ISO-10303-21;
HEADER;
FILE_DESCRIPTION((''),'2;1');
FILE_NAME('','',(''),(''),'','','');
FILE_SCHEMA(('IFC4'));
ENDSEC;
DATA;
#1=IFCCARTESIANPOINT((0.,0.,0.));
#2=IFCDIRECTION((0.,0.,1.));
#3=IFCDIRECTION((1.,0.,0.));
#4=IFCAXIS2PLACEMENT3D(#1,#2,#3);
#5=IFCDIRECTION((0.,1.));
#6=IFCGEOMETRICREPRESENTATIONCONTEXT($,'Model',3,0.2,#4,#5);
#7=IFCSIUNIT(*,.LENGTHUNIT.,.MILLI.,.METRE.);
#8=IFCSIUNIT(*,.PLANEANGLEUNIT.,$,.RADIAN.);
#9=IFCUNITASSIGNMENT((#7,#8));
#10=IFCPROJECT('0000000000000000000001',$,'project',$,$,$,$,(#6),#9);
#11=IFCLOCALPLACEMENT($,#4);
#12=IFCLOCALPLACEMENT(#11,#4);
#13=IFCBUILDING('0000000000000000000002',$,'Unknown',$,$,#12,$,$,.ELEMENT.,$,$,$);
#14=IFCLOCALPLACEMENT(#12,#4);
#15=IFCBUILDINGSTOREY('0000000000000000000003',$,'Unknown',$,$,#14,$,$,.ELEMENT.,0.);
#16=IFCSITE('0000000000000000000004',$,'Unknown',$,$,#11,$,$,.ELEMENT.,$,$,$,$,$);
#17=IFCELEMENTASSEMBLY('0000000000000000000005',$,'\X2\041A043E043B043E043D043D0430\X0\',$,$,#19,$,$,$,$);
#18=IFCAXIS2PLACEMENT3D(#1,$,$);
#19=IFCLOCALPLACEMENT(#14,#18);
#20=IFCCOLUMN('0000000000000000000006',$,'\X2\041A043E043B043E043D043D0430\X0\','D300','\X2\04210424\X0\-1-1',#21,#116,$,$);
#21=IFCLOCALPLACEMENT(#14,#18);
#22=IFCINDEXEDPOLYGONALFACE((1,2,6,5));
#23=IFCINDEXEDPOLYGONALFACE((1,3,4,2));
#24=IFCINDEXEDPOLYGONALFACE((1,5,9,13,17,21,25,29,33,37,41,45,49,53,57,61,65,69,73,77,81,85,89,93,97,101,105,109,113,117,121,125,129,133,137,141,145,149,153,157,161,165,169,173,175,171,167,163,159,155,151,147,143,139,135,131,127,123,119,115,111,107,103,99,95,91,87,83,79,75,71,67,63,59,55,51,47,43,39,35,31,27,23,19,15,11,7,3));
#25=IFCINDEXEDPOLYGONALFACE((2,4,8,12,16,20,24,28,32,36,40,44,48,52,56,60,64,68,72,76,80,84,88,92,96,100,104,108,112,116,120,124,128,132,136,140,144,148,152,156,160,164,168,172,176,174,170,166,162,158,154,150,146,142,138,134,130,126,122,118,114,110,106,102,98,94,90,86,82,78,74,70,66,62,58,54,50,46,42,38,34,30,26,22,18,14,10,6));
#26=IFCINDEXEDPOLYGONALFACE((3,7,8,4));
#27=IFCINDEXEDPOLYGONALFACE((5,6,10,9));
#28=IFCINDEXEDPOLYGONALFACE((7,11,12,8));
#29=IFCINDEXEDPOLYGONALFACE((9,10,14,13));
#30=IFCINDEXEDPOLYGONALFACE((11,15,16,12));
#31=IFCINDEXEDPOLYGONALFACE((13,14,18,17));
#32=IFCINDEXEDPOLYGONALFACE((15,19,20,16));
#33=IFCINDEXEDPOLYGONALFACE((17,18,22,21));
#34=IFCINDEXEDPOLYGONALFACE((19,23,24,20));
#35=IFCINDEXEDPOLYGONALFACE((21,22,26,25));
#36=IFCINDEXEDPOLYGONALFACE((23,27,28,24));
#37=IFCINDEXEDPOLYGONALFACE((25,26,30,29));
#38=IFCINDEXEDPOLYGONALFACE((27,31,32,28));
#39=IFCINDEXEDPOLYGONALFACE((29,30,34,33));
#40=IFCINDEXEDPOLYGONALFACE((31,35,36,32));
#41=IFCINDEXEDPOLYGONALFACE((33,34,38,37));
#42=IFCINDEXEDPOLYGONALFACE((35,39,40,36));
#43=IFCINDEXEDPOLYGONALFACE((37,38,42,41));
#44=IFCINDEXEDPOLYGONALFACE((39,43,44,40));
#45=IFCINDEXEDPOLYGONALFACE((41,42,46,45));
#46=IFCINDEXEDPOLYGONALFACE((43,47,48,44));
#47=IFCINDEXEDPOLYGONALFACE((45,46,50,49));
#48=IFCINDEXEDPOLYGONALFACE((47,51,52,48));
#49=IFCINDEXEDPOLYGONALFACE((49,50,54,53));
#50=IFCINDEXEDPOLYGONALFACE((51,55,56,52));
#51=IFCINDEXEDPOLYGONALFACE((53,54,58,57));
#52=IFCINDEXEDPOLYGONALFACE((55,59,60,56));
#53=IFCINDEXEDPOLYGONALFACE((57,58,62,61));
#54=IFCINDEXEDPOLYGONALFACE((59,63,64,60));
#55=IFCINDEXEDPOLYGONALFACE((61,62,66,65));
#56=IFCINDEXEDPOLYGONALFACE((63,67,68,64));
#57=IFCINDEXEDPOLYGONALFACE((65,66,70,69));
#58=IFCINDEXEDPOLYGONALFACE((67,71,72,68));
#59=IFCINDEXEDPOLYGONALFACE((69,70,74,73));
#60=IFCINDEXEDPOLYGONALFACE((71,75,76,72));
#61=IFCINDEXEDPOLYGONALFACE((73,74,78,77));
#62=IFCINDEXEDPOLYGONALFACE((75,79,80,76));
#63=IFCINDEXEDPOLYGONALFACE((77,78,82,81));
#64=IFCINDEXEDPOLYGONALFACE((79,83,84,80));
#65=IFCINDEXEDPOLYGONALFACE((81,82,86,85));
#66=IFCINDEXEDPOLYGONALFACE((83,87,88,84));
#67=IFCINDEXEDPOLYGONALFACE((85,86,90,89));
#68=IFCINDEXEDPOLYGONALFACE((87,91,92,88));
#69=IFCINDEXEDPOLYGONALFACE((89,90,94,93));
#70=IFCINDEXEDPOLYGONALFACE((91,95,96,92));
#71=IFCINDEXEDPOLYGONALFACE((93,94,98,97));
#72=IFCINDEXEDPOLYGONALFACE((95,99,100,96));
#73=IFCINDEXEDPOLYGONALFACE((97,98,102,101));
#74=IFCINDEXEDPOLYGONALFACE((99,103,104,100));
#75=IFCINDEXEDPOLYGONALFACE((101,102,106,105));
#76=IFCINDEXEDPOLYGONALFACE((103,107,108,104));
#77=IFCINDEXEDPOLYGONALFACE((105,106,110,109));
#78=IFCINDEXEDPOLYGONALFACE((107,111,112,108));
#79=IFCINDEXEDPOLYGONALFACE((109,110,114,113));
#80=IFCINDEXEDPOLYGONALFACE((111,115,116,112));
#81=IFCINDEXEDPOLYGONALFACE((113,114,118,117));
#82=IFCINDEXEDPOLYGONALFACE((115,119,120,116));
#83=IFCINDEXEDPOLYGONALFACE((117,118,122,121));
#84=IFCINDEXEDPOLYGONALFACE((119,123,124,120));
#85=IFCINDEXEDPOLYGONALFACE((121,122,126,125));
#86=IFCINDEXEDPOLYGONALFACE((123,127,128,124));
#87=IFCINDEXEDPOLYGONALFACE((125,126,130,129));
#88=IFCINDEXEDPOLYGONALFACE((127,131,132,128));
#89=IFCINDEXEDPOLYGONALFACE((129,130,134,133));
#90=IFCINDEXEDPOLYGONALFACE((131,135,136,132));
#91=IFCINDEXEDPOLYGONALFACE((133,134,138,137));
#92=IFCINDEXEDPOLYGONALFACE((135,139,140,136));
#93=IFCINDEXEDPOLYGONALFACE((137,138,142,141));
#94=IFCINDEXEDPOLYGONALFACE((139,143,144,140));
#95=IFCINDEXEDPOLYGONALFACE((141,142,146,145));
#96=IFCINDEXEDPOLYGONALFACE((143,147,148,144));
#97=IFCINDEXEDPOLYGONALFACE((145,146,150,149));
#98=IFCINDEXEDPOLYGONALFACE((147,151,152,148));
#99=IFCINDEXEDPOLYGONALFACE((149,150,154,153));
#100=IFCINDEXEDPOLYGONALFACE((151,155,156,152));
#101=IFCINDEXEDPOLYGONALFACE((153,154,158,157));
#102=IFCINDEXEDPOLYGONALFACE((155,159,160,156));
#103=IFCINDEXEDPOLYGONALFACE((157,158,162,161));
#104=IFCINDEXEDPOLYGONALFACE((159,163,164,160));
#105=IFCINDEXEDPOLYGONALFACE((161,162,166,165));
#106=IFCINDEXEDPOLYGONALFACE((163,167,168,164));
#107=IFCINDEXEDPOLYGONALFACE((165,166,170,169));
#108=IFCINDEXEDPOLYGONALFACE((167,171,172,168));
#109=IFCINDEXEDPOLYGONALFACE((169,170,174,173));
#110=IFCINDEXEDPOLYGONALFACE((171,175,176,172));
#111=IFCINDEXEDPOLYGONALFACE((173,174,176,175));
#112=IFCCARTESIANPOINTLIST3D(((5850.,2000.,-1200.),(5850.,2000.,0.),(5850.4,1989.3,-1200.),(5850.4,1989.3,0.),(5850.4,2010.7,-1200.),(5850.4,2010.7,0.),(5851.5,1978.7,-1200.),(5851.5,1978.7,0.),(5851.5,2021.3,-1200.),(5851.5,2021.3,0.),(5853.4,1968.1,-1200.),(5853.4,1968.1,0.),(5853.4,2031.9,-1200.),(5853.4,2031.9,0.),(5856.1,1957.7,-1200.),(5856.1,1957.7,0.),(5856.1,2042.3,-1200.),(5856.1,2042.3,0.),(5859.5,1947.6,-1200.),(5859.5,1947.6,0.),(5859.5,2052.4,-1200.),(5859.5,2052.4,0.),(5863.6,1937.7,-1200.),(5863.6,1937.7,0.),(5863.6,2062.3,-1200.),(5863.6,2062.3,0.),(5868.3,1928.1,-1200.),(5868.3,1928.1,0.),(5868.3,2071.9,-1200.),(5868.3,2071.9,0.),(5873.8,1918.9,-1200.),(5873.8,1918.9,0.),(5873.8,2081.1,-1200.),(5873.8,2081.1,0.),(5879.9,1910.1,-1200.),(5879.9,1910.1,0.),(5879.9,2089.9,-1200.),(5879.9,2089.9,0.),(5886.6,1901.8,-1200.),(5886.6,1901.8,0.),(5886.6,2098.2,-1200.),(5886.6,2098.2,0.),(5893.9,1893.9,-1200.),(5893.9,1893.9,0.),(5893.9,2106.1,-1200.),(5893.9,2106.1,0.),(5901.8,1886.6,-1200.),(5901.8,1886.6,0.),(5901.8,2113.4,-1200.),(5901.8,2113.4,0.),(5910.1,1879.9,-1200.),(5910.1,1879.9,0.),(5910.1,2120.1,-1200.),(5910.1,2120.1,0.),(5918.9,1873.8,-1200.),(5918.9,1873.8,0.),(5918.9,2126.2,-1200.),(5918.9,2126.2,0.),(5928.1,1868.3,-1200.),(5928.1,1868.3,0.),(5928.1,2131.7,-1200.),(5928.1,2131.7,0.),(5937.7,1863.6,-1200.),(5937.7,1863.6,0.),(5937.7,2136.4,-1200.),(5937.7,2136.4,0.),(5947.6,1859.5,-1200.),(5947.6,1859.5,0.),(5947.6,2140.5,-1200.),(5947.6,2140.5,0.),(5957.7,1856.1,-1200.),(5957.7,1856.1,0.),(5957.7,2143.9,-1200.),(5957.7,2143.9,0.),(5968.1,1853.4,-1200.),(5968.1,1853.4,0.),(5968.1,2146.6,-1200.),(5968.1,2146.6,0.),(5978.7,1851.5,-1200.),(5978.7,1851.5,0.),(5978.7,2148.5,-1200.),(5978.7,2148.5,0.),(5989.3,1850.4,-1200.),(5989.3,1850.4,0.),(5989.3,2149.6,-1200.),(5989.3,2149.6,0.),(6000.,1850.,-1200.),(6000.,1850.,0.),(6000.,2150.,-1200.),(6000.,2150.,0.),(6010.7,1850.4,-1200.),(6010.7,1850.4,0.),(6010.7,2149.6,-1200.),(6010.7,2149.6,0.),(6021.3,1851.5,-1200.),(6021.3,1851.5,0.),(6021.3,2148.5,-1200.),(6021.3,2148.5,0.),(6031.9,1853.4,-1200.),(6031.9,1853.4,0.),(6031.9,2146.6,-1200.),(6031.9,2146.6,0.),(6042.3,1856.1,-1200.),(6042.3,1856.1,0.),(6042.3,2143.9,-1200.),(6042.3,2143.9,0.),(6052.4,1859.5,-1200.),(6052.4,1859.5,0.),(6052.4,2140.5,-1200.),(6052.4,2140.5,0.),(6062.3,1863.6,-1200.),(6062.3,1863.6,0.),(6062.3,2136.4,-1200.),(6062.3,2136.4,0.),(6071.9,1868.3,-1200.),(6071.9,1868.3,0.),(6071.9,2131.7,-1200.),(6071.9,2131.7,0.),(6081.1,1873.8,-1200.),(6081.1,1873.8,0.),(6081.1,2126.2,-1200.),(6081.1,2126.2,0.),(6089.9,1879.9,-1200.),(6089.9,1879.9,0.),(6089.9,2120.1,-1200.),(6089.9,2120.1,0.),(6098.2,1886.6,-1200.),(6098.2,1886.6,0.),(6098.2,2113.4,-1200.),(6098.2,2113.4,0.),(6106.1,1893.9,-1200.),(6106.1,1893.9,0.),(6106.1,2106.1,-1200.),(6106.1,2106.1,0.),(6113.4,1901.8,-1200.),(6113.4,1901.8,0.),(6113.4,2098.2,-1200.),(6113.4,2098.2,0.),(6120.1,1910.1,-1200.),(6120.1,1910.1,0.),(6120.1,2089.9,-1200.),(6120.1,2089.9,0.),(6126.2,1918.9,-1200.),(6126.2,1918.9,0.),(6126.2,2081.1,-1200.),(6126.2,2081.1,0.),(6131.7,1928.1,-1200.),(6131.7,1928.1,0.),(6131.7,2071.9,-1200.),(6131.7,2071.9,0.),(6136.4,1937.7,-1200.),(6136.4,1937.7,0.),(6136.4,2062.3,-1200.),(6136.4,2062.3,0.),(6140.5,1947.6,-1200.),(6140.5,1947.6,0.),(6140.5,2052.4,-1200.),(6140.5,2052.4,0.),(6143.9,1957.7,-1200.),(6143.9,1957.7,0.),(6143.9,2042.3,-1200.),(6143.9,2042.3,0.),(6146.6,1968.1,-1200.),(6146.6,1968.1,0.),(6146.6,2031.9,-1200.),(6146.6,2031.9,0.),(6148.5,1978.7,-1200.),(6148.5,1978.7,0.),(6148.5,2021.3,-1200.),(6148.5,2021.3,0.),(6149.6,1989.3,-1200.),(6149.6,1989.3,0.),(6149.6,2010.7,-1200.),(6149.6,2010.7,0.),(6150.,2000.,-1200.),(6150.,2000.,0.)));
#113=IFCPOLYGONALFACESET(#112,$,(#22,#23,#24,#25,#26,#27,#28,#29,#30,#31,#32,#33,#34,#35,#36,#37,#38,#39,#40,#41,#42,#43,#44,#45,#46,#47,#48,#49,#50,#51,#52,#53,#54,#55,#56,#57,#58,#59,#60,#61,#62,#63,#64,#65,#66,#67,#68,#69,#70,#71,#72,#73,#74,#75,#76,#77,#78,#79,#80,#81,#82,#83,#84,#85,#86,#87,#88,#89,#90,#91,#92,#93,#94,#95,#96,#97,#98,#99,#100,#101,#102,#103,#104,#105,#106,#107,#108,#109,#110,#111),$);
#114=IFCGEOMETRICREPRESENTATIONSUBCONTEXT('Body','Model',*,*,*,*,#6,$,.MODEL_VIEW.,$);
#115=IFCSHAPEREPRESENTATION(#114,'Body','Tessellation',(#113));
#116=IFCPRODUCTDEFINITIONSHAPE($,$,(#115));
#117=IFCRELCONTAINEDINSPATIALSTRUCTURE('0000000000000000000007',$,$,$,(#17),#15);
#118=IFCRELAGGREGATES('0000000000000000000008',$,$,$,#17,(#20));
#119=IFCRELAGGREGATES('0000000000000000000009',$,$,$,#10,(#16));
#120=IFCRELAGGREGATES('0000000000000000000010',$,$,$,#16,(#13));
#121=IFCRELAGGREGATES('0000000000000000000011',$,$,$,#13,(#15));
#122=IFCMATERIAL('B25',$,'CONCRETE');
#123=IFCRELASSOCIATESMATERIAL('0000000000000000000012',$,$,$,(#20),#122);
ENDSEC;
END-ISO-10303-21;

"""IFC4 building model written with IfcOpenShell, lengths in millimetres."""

from ifc_helpers import new_model, si_unit, direction, frame, origin_with_axes, place, context, subcontext, project, spatial, line, indexed_curve, outline, extrude, material, element, aggregate, save


model = new_model("IFC4")

# Units and contexts
model_context = context("Model", 3, precision=0.2, world=origin_with_axes(), true_north=direction((0.0, 1.0)))
body_context = subcontext(model_context, "Body", "Model", "MODEL_VIEW")
ifc_project = project(units=[si_unit("LENGTHUNIT", "METRE", prefix="MILLI"), si_unit("PLANEANGLEUNIT", "RADIAN")], contexts=[model_context])

# Site, building, storey
site_placement = place(None, origin_with_axes())
site = spatial("IfcSite", under=ifc_project, at=site_placement, Name="Unknown", CompositionType="ELEMENT")
building_placement = place(site_placement, origin_with_axes())
building = spatial("IfcBuilding", under=site, at=building_placement, Name="Unknown", CompositionType="ELEMENT")
storey_placement = place(building_placement, origin_with_axes())
storey = spatial("IfcBuildingStorey", under=building, at=storey_placement, Name="Unknown", CompositionType="ELEMENT", Elevation=0.0)

# Element assembly, column
assembly_1_placement = place(storey_placement, frame((6000.0, 2000.0, -1200.0), z_axis=(-1.0, 0.0, 0.0), x_axis=(0.0, 0.0, 1.0)))
assembly_1 = element("IfcElementAssembly", 1, at=assembly_1_placement, inside=storey, Name="Колонна")
ifc_material_1 = material(Name="B25", Category="CONCRETE")
column_1_placement = place(assembly_1_placement, origin_with_axes())
column_1 = element("IfcColumn", 2, at=column_1_placement, material=ifc_material_1, Name="Колонна", Description="D300", ObjectType="СФ-1-1", context=body_context, shape_type="SolidModel", body=[
    extrude(outline(indexed_curve([(150.0, 0.0), (149.6, 10.7), (148.5, 21.3), (146.6, 31.9), (143.9, 42.3), (140.5, 52.4), (136.4, 62.3), (131.7, 71.9), (126.2, 81.1), (120.1, 89.9), (113.4, 98.2), (106.1, 106.1), (98.2, 113.4), (89.9, 120.1), (81.1, 126.2), (71.9, 131.7), (62.3, 136.4), (52.4, 140.5), (42.3, 143.9), (31.9, 146.6), (21.3, 148.5), (10.7, 149.6), (0.0, 150.0), (-10.7, 149.6), (-21.3, 148.5), (-31.9, 146.6), (-42.3, 143.9), (-52.4, 140.5), (-62.3, 136.4), (-71.9, 131.7), (-81.1, 126.2), (-89.9, 120.1), (-98.2, 113.4), (-106.1, 106.1), (-113.4, 98.2), (-120.1, 89.9), (-126.2, 81.1), (-131.7, 71.9), (-136.4, 62.3), (-140.5, 52.4), (-143.9, 42.3), (-146.6, 31.9), (-148.5, 21.3), (-149.6, 10.7), (-150.0, 0.0), (-149.6, -10.7), (-148.5, -21.3), (-146.6, -31.9), (-143.9, -42.3), (-140.5, -52.4), (-136.4, -62.3), (-131.7, -71.9), (-126.2, -81.1), (-120.1, -89.9), (-113.4, -98.2), (-106.1, -106.1), (-98.2, -113.4), (-89.9, -120.1), (-81.1, -126.2), (-71.9, -131.7), (-62.3, -136.4), (-52.4, -140.5), (-42.3, -143.9), (-31.9, -146.6), (-21.3, -148.5), (-10.7, -149.6), (0.0, -150.0), (10.7, -149.6), (21.3, -148.5), (31.9, -146.6), (42.3, -143.9), (52.4, -140.5), (62.3, -136.4), (71.9, -131.7), (81.1, -126.2), (89.9, -120.1), (98.2, -113.4), (106.1, -106.1), (113.4, -98.2), (120.1, -89.9), (126.2, -81.1), (131.7, -71.9), (136.4, -62.3), (140.5, -52.4), (143.9, -42.3), (146.6, -31.9), (148.5, -21.3), (149.6, -10.7)], segments=[line(1, 2, 3, 4, 5, 6, 7, 8, 9, 10, 11, 12, 13, 14, 15, 16, 17, 18, 19, 20, 21, 22, 23, 24, 25, 26, 27, 28, 29, 30, 31, 32, 33, 34, 35, 36, 37, 38, 39, 40, 41, 42, 43, 44, 45, 46, 47, 48, 49, 50, 51, 52, 53, 54, 55, 56, 57, 58, 59, 60, 61, 62, 63, 64, 65, 66, 67, 68, 69, 70, 71, 72, 73, 74, 75, 76, 77, 78, 79, 80, 81, 82, 83, 84, 85, 86, 87, 88, 1)])), frame((0.0, 0.0, 0.0), z_axis=(-1.0, 0.0, 0.0), x_axis=(0.0, 0.0, 1.0)), (0.0, 0.0, -1.0), 1200.0),
])
aggregate(assembly_1, [column_1])

save(model, "model.ifc")
